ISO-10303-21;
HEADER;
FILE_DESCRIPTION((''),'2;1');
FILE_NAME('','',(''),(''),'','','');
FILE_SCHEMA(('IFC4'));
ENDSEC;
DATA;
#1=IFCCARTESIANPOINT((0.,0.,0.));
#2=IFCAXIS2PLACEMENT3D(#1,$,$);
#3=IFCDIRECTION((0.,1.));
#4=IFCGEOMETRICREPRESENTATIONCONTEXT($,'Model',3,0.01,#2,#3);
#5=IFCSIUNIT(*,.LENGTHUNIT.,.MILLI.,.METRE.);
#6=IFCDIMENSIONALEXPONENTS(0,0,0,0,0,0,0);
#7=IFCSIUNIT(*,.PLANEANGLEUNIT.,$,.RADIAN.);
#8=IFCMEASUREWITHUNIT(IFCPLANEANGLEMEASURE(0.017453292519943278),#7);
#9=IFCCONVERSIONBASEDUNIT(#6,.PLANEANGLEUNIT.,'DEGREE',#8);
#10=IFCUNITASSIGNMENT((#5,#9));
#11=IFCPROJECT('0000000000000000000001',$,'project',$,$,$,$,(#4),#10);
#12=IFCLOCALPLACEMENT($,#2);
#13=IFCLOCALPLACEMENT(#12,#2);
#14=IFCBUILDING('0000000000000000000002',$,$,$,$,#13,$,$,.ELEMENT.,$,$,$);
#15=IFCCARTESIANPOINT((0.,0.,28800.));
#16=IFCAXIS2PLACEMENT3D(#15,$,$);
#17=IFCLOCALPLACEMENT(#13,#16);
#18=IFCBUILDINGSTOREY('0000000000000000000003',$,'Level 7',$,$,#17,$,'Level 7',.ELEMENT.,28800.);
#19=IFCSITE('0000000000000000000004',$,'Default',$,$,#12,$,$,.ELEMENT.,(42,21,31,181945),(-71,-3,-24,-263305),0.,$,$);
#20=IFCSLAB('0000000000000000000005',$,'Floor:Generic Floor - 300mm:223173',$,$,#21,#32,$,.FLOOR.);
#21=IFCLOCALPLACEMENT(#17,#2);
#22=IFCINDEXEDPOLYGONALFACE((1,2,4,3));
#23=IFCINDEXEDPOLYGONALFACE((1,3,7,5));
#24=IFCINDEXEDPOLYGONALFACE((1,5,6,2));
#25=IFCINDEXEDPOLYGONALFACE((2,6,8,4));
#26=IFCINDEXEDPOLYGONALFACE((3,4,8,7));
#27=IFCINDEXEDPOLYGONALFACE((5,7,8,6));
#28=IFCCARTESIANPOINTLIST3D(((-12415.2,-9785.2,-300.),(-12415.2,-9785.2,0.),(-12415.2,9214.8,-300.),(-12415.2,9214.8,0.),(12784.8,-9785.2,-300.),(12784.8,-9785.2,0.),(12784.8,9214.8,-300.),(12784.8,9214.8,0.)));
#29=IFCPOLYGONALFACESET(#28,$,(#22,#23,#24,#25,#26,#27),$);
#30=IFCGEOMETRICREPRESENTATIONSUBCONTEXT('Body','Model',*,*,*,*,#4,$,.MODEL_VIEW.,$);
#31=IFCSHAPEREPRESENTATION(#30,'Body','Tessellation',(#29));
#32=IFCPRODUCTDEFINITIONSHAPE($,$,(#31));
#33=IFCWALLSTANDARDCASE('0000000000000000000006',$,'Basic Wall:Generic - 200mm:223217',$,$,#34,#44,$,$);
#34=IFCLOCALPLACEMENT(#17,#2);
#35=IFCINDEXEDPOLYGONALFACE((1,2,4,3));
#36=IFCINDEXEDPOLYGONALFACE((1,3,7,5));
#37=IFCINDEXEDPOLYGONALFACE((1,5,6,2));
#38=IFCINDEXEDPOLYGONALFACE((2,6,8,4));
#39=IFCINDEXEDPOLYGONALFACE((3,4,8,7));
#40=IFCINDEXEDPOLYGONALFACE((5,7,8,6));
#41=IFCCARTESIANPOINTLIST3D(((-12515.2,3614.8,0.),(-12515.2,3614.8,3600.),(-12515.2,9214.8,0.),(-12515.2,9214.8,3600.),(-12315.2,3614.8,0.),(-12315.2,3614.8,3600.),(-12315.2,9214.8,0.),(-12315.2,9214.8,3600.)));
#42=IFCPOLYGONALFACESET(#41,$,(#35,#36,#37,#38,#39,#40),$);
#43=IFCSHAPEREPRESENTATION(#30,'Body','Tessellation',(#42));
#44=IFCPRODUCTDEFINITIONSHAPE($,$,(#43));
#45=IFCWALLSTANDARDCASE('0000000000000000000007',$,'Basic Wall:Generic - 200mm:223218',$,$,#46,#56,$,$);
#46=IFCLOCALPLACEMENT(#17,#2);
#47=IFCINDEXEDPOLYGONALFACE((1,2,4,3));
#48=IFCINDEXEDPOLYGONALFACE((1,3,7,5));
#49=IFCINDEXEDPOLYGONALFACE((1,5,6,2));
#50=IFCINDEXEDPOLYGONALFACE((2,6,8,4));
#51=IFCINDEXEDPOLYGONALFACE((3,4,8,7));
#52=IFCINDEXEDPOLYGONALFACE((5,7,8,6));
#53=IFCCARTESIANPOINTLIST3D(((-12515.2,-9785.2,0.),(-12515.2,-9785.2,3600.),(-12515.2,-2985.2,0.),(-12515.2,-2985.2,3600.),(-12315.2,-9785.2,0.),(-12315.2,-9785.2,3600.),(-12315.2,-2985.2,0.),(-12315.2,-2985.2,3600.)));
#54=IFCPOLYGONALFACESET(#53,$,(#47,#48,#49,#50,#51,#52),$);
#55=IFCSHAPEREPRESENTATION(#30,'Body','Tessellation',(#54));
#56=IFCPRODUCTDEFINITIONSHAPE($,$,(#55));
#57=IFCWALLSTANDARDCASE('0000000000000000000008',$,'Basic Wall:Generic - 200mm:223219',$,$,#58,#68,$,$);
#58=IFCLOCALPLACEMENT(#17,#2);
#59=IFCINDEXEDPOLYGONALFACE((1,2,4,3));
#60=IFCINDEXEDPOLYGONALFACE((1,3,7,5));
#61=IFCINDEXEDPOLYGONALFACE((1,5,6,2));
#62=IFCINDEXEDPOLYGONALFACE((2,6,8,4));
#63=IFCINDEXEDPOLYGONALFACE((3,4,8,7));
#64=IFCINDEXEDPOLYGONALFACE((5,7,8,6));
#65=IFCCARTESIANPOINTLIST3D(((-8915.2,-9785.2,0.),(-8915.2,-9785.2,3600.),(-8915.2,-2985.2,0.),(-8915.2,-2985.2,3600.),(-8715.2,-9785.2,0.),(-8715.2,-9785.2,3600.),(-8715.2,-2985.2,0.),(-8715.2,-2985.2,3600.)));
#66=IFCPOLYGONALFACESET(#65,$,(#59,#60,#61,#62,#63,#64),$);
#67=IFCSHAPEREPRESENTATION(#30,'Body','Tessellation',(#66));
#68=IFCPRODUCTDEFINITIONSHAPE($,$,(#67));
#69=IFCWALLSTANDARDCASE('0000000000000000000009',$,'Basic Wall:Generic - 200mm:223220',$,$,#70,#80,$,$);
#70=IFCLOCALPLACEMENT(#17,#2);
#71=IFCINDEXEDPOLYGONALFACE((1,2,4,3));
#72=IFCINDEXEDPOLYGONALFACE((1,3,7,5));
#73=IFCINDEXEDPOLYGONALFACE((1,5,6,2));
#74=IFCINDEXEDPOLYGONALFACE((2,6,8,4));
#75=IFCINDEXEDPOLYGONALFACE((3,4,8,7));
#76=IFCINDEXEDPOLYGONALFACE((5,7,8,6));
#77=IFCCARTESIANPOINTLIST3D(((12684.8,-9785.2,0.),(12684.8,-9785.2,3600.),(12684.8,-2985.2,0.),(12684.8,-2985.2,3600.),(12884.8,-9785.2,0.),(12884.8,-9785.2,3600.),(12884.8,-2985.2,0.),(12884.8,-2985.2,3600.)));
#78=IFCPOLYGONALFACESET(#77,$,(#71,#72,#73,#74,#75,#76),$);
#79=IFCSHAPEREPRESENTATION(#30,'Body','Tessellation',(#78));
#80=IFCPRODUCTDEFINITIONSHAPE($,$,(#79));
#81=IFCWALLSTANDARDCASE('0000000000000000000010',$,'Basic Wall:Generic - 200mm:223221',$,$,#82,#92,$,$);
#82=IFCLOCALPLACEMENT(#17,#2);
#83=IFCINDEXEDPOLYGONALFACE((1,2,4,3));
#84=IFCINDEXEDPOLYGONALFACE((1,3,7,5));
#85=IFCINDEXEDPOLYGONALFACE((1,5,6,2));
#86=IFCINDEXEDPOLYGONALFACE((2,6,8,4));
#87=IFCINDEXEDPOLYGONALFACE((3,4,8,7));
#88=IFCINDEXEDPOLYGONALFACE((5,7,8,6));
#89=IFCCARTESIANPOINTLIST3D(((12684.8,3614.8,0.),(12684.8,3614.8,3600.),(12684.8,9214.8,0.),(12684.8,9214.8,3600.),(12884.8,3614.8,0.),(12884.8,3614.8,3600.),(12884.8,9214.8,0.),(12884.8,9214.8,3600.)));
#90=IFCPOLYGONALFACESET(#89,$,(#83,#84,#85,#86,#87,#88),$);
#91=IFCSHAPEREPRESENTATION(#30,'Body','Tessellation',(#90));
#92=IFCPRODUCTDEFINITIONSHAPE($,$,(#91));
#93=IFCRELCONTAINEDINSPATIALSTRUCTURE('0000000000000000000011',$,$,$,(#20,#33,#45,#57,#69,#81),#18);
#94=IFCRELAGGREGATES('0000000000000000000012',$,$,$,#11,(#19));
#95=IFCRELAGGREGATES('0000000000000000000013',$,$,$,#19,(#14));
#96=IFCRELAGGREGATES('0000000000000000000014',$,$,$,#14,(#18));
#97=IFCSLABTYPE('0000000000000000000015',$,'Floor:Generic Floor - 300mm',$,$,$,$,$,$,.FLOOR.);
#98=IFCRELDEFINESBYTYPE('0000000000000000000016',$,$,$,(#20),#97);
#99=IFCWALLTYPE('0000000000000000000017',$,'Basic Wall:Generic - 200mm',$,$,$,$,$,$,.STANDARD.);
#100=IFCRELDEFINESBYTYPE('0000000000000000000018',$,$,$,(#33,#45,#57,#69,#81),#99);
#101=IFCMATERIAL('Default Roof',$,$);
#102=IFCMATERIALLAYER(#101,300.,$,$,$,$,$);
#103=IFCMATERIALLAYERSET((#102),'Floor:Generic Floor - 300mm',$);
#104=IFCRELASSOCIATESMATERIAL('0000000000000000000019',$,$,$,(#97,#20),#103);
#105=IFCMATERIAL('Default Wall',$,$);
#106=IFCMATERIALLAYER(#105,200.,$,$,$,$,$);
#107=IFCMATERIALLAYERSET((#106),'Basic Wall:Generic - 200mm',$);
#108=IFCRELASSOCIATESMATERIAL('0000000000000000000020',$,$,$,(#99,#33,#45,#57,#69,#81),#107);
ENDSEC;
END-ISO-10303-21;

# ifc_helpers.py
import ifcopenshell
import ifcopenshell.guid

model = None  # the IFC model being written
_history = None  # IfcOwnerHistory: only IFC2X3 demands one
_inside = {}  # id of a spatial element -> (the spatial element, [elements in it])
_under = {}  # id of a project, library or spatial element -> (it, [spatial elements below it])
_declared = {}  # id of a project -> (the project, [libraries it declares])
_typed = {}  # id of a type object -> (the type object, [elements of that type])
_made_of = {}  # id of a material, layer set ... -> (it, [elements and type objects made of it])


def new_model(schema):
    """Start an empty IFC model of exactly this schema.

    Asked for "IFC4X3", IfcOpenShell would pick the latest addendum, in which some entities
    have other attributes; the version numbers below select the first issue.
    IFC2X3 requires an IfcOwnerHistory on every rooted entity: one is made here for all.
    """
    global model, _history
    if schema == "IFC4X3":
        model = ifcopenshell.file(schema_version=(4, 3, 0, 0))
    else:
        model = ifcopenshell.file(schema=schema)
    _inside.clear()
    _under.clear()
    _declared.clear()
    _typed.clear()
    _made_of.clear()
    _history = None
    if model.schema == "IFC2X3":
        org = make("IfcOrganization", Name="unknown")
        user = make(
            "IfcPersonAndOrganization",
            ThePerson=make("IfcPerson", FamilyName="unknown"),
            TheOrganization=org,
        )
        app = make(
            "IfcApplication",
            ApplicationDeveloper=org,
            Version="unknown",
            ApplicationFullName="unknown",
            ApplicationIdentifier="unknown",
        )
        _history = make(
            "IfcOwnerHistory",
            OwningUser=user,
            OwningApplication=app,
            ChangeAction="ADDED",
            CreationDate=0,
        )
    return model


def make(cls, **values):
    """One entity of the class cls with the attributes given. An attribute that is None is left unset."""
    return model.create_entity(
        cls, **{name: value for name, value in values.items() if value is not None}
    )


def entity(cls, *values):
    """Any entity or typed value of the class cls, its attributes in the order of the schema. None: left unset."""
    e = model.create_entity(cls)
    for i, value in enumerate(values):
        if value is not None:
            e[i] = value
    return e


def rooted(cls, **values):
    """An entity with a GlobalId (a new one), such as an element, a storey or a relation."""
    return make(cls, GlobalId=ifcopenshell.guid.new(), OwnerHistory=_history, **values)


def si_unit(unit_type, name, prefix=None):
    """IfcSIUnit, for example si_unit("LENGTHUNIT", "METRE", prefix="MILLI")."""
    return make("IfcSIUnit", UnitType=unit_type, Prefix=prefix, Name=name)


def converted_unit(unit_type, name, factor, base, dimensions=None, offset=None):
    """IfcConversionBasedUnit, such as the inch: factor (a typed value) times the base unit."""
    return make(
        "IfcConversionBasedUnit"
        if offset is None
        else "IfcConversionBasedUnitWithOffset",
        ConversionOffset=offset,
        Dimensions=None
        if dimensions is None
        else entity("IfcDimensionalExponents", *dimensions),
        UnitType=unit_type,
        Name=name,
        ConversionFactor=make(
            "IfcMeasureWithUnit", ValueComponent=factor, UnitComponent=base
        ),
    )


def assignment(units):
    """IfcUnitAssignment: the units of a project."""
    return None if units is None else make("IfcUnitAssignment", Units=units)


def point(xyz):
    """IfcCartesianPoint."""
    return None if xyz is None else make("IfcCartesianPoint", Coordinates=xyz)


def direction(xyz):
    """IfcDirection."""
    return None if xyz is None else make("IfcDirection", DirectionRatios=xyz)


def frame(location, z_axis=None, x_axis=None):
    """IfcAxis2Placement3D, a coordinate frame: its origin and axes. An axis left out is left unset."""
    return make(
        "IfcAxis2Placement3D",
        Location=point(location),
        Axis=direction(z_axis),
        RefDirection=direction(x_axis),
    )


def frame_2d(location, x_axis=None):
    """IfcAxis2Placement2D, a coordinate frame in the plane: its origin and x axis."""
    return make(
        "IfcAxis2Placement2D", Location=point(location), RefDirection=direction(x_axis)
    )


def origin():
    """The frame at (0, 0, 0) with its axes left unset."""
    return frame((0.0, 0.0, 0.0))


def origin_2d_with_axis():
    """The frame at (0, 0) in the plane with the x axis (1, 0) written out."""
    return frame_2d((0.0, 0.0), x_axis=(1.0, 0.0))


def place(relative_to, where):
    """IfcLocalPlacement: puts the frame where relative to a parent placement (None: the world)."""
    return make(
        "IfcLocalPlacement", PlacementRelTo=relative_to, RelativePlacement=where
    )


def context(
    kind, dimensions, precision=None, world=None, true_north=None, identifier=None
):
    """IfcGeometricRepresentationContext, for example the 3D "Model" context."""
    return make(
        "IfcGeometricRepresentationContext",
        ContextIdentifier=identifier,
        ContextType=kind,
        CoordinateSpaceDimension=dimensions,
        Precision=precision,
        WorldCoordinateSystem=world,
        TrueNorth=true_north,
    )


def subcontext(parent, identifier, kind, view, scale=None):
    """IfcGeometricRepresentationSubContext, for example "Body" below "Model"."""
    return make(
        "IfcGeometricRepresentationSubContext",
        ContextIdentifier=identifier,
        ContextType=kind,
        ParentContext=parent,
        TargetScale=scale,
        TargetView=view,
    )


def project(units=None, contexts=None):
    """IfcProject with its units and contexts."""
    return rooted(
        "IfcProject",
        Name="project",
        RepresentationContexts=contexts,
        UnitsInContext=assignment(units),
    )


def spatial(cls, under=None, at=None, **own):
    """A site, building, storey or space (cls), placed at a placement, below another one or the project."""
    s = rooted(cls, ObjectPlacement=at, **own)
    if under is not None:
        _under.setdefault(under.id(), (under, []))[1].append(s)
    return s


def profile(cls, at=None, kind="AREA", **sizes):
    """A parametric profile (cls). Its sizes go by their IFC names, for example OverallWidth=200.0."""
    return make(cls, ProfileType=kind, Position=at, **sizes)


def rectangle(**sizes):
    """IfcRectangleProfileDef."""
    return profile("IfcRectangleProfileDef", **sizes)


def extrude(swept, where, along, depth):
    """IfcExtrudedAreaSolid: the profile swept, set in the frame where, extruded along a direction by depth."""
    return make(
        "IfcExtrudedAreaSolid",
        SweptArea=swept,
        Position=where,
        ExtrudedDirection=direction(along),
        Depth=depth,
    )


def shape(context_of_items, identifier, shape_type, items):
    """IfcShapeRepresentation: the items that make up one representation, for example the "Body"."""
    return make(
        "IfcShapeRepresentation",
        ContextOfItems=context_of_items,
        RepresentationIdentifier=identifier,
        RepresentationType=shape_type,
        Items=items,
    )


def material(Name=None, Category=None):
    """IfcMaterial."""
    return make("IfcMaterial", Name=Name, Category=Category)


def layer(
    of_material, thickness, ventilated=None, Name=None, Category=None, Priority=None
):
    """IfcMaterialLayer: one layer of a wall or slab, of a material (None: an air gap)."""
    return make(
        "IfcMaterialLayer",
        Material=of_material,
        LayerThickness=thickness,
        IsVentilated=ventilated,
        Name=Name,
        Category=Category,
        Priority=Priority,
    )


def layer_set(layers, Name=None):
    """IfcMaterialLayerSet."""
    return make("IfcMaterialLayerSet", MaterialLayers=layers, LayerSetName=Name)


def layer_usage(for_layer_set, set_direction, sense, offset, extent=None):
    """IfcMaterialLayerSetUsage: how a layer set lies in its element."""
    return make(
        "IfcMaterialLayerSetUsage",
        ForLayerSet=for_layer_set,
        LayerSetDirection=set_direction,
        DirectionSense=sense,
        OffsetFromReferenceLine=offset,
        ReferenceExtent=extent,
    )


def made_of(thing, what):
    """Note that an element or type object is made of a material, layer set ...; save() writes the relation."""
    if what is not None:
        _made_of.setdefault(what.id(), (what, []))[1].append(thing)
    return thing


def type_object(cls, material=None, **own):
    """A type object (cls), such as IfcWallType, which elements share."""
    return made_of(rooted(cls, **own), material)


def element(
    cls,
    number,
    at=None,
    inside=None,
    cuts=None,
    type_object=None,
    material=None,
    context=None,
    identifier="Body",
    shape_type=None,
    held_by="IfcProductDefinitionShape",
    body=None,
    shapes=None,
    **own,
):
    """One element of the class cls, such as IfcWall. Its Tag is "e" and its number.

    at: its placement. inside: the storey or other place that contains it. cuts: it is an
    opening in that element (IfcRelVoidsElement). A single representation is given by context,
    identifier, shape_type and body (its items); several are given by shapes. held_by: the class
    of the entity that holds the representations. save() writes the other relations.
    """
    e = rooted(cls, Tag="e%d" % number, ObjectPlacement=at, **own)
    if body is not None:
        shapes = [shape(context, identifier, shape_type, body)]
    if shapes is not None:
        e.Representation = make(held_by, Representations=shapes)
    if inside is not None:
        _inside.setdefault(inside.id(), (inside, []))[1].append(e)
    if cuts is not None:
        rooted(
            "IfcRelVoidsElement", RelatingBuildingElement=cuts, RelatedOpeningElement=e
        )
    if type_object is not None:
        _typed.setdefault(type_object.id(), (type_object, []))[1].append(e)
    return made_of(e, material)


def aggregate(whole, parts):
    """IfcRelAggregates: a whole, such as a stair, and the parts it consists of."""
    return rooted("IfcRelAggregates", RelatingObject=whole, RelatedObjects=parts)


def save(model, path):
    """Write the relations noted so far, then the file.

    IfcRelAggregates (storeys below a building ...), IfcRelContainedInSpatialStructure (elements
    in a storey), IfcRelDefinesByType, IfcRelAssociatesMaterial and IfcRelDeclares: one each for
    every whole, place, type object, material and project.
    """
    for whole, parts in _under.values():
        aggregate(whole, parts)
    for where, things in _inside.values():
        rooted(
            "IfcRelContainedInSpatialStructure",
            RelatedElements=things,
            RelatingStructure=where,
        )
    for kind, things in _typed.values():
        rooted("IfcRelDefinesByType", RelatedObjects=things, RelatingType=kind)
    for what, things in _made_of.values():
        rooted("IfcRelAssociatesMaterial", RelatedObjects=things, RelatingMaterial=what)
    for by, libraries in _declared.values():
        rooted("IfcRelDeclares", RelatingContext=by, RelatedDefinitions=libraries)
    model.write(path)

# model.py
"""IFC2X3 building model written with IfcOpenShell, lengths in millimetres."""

from ifc_helpers import new_model, entity, si_unit, converted_unit, direction, frame, frame_2d, origin, origin_2d_with_axis, place, context, subcontext, project, spatial, rectangle, extrude, material, layer, layer_set, layer_usage, type_object, element, save


model = new_model("IFC2X3")

# Units and contexts
model_context = context("Model", 3, precision=0.01, world=origin(), true_north=direction((0.0, 1.0)))
body_context = subcontext(model_context, "Body", "Model", "MODEL_VIEW")
ifc_project = project(units=[si_unit("LENGTHUNIT", "METRE", prefix="MILLI"), converted_unit("PLANEANGLEUNIT", "DEGREE", entity("IfcPlaneAngleMeasure", 0.017453292519943278), si_unit("PLANEANGLEUNIT", "RADIAN"), dimensions=[0, 0, 0, 0, 0, 0, 0])], contexts=[model_context])

# Site, building, storey
site_placement = place(None, origin())
site = spatial("IfcSite", under=ifc_project, at=site_placement, Name="Default", CompositionType="ELEMENT", RefLatitude=(42, 21, 31, 181945), RefLongitude=(-71, -3, -24, -263305), RefElevation=0.0)
building_placement = place(site_placement, origin())
building = spatial("IfcBuilding", under=site, at=building_placement, CompositionType="ELEMENT")
storey_placement = place(building_placement, frame((0.0, 0.0, 28800.0)))
storey = spatial("IfcBuildingStorey", under=building, at=storey_placement, Name="Level 7", LongName="Level 7", CompositionType="ELEMENT", Elevation=28800.0)

# Slab
ifc_material_1 = material(Name="Default Roof")
ifc_layer_1 = layer(ifc_material_1, 300.0)
ifc_layer_set_1 = layer_set([ifc_layer_1], Name="Floor:Generic Floor - 300mm")
ifc_layer_usage_1 = layer_usage(ifc_layer_set_1, "AXIS3", "POSITIVE", 0.0)
slab_type = type_object("IfcSlabType", Name="Floor:Generic Floor - 300mm", PredefinedType="FLOOR", material=ifc_layer_set_1)
slab_placement = place(storey_placement, origin())
element("IfcSlab", 1, at=slab_placement, inside=storey, type_object=slab_type, material=ifc_layer_usage_1, Name="Floor:Generic Floor - 300mm:223173", PredefinedType="FLOOR", context=body_context, shape_type="SweptSolid", body=[
    extrude(rectangle(XDim=19000.0, YDim=25200.0, at=origin_2d_with_axis()), frame((184.8, -285.2, 0.0), z_axis=(0.0, 0.0, -1.0), x_axis=(0.0, 1.0, 0.0)), (0.0, 0.0, 1.0), 300.0),
])

# Walls
ifc_material_2 = material(Name="Default Wall")
ifc_layer_2 = layer(ifc_material_2, 200.0)
ifc_layer_set_2 = layer_set([ifc_layer_2], Name="Basic Wall:Generic - 200mm")
ifc_layer_usage_2 = layer_usage(ifc_layer_set_2, "AXIS2", "NEGATIVE", 100.0)
wall_type = type_object("IfcWallType", Name="Basic Wall:Generic - 200mm", PredefinedType="STANDARD", material=ifc_layer_set_2)
wall_1_placement = place(storey_placement, frame((-12415.2, 3614.8, 0.0), z_axis=(0.0, 0.0, 1.0), x_axis=(0.0, 1.0, 0.0)))
element("IfcWallStandardCase", 2, at=wall_1_placement, inside=storey, type_object=wall_type, material=ifc_layer_usage_2, Name="Basic Wall:Generic - 200mm:223217", context=body_context, shape_type="SweptSolid", body=[
    extrude(rectangle(XDim=5600.0, YDim=200.0, at=frame_2d((2800.0, 0.0), x_axis=(-1.0, 0.0))), origin(), (0.0, 0.0, 1.0), 3600.0),
])
ifc_layer_usage_3 = layer_usage(ifc_layer_set_2, "AXIS2", "NEGATIVE", 100.0)
wall_2_placement = place(storey_placement, frame((-12415.2, -9785.2, 0.0), z_axis=(0.0, 0.0, 1.0), x_axis=(0.0, 1.0, 0.0)))
element("IfcWallStandardCase", 3, at=wall_2_placement, inside=storey, type_object=wall_type, material=ifc_layer_usage_3, Name="Basic Wall:Generic - 200mm:223218", context=body_context, shape_type="SweptSolid", body=[
    extrude(rectangle(XDim=6800.0, YDim=200.0, at=frame_2d((3400.0, 0.0), x_axis=(-1.0, 0.0))), origin(), (0.0, 0.0, 1.0), 3600.0),
])
ifc_layer_usage_4 = layer_usage(ifc_layer_set_2, "AXIS2", "NEGATIVE", 100.0)
wall_3_placement = place(storey_placement, frame((-8815.2, -9785.2, 0.0), z_axis=(0.0, 0.0, 1.0), x_axis=(0.0, 1.0, 0.0)))
element("IfcWallStandardCase", 4, at=wall_3_placement, inside=storey, type_object=wall_type, material=ifc_layer_usage_4, Name="Basic Wall:Generic - 200mm:223219", context=body_context, shape_type="SweptSolid", body=[
    extrude(rectangle(XDim=6800.0, YDim=200.0, at=frame_2d((3400.0, 0.0), x_axis=(-1.0, 0.0))), origin(), (0.0, 0.0, 1.0), 3600.0),
])
ifc_layer_usage_5 = layer_usage(ifc_layer_set_2, "AXIS2", "NEGATIVE", 100.0)
wall_4_placement = place(storey_placement, frame((12784.8, -9785.2, 0.0), z_axis=(0.0, 0.0, 1.0), x_axis=(0.0, 1.0, 0.0)))
element("IfcWallStandardCase", 5, at=wall_4_placement, inside=storey, type_object=wall_type, material=ifc_layer_usage_5, Name="Basic Wall:Generic - 200mm:223220", context=body_context, shape_type="SweptSolid", body=[
    extrude(rectangle(XDim=6800.0, YDim=200.0, at=frame_2d((3400.0, 0.0), x_axis=(-1.0, 0.0))), origin(), (0.0, 0.0, 1.0), 3600.0),
])
ifc_layer_usage_6 = layer_usage(ifc_layer_set_2, "AXIS2", "NEGATIVE", 100.0)
wall_5_placement = place(storey_placement, frame((12784.8, 3614.8, 0.0), z_axis=(0.0, 0.0, 1.0), x_axis=(0.0, 1.0, 0.0)))
element("IfcWallStandardCase", 6, at=wall_5_placement, inside=storey, type_object=wall_type, material=ifc_layer_usage_6, Name="Basic Wall:Generic - 200mm:223221", context=body_context, shape_type="SweptSolid", body=[
    extrude(rectangle(XDim=5600.0, YDim=200.0, at=frame_2d((2800.0, 0.0), x_axis=(-1.0, 0.0))), origin(), (0.0, 0.0, 1.0), 3600.0),
])

save(model, "model.ifc")
